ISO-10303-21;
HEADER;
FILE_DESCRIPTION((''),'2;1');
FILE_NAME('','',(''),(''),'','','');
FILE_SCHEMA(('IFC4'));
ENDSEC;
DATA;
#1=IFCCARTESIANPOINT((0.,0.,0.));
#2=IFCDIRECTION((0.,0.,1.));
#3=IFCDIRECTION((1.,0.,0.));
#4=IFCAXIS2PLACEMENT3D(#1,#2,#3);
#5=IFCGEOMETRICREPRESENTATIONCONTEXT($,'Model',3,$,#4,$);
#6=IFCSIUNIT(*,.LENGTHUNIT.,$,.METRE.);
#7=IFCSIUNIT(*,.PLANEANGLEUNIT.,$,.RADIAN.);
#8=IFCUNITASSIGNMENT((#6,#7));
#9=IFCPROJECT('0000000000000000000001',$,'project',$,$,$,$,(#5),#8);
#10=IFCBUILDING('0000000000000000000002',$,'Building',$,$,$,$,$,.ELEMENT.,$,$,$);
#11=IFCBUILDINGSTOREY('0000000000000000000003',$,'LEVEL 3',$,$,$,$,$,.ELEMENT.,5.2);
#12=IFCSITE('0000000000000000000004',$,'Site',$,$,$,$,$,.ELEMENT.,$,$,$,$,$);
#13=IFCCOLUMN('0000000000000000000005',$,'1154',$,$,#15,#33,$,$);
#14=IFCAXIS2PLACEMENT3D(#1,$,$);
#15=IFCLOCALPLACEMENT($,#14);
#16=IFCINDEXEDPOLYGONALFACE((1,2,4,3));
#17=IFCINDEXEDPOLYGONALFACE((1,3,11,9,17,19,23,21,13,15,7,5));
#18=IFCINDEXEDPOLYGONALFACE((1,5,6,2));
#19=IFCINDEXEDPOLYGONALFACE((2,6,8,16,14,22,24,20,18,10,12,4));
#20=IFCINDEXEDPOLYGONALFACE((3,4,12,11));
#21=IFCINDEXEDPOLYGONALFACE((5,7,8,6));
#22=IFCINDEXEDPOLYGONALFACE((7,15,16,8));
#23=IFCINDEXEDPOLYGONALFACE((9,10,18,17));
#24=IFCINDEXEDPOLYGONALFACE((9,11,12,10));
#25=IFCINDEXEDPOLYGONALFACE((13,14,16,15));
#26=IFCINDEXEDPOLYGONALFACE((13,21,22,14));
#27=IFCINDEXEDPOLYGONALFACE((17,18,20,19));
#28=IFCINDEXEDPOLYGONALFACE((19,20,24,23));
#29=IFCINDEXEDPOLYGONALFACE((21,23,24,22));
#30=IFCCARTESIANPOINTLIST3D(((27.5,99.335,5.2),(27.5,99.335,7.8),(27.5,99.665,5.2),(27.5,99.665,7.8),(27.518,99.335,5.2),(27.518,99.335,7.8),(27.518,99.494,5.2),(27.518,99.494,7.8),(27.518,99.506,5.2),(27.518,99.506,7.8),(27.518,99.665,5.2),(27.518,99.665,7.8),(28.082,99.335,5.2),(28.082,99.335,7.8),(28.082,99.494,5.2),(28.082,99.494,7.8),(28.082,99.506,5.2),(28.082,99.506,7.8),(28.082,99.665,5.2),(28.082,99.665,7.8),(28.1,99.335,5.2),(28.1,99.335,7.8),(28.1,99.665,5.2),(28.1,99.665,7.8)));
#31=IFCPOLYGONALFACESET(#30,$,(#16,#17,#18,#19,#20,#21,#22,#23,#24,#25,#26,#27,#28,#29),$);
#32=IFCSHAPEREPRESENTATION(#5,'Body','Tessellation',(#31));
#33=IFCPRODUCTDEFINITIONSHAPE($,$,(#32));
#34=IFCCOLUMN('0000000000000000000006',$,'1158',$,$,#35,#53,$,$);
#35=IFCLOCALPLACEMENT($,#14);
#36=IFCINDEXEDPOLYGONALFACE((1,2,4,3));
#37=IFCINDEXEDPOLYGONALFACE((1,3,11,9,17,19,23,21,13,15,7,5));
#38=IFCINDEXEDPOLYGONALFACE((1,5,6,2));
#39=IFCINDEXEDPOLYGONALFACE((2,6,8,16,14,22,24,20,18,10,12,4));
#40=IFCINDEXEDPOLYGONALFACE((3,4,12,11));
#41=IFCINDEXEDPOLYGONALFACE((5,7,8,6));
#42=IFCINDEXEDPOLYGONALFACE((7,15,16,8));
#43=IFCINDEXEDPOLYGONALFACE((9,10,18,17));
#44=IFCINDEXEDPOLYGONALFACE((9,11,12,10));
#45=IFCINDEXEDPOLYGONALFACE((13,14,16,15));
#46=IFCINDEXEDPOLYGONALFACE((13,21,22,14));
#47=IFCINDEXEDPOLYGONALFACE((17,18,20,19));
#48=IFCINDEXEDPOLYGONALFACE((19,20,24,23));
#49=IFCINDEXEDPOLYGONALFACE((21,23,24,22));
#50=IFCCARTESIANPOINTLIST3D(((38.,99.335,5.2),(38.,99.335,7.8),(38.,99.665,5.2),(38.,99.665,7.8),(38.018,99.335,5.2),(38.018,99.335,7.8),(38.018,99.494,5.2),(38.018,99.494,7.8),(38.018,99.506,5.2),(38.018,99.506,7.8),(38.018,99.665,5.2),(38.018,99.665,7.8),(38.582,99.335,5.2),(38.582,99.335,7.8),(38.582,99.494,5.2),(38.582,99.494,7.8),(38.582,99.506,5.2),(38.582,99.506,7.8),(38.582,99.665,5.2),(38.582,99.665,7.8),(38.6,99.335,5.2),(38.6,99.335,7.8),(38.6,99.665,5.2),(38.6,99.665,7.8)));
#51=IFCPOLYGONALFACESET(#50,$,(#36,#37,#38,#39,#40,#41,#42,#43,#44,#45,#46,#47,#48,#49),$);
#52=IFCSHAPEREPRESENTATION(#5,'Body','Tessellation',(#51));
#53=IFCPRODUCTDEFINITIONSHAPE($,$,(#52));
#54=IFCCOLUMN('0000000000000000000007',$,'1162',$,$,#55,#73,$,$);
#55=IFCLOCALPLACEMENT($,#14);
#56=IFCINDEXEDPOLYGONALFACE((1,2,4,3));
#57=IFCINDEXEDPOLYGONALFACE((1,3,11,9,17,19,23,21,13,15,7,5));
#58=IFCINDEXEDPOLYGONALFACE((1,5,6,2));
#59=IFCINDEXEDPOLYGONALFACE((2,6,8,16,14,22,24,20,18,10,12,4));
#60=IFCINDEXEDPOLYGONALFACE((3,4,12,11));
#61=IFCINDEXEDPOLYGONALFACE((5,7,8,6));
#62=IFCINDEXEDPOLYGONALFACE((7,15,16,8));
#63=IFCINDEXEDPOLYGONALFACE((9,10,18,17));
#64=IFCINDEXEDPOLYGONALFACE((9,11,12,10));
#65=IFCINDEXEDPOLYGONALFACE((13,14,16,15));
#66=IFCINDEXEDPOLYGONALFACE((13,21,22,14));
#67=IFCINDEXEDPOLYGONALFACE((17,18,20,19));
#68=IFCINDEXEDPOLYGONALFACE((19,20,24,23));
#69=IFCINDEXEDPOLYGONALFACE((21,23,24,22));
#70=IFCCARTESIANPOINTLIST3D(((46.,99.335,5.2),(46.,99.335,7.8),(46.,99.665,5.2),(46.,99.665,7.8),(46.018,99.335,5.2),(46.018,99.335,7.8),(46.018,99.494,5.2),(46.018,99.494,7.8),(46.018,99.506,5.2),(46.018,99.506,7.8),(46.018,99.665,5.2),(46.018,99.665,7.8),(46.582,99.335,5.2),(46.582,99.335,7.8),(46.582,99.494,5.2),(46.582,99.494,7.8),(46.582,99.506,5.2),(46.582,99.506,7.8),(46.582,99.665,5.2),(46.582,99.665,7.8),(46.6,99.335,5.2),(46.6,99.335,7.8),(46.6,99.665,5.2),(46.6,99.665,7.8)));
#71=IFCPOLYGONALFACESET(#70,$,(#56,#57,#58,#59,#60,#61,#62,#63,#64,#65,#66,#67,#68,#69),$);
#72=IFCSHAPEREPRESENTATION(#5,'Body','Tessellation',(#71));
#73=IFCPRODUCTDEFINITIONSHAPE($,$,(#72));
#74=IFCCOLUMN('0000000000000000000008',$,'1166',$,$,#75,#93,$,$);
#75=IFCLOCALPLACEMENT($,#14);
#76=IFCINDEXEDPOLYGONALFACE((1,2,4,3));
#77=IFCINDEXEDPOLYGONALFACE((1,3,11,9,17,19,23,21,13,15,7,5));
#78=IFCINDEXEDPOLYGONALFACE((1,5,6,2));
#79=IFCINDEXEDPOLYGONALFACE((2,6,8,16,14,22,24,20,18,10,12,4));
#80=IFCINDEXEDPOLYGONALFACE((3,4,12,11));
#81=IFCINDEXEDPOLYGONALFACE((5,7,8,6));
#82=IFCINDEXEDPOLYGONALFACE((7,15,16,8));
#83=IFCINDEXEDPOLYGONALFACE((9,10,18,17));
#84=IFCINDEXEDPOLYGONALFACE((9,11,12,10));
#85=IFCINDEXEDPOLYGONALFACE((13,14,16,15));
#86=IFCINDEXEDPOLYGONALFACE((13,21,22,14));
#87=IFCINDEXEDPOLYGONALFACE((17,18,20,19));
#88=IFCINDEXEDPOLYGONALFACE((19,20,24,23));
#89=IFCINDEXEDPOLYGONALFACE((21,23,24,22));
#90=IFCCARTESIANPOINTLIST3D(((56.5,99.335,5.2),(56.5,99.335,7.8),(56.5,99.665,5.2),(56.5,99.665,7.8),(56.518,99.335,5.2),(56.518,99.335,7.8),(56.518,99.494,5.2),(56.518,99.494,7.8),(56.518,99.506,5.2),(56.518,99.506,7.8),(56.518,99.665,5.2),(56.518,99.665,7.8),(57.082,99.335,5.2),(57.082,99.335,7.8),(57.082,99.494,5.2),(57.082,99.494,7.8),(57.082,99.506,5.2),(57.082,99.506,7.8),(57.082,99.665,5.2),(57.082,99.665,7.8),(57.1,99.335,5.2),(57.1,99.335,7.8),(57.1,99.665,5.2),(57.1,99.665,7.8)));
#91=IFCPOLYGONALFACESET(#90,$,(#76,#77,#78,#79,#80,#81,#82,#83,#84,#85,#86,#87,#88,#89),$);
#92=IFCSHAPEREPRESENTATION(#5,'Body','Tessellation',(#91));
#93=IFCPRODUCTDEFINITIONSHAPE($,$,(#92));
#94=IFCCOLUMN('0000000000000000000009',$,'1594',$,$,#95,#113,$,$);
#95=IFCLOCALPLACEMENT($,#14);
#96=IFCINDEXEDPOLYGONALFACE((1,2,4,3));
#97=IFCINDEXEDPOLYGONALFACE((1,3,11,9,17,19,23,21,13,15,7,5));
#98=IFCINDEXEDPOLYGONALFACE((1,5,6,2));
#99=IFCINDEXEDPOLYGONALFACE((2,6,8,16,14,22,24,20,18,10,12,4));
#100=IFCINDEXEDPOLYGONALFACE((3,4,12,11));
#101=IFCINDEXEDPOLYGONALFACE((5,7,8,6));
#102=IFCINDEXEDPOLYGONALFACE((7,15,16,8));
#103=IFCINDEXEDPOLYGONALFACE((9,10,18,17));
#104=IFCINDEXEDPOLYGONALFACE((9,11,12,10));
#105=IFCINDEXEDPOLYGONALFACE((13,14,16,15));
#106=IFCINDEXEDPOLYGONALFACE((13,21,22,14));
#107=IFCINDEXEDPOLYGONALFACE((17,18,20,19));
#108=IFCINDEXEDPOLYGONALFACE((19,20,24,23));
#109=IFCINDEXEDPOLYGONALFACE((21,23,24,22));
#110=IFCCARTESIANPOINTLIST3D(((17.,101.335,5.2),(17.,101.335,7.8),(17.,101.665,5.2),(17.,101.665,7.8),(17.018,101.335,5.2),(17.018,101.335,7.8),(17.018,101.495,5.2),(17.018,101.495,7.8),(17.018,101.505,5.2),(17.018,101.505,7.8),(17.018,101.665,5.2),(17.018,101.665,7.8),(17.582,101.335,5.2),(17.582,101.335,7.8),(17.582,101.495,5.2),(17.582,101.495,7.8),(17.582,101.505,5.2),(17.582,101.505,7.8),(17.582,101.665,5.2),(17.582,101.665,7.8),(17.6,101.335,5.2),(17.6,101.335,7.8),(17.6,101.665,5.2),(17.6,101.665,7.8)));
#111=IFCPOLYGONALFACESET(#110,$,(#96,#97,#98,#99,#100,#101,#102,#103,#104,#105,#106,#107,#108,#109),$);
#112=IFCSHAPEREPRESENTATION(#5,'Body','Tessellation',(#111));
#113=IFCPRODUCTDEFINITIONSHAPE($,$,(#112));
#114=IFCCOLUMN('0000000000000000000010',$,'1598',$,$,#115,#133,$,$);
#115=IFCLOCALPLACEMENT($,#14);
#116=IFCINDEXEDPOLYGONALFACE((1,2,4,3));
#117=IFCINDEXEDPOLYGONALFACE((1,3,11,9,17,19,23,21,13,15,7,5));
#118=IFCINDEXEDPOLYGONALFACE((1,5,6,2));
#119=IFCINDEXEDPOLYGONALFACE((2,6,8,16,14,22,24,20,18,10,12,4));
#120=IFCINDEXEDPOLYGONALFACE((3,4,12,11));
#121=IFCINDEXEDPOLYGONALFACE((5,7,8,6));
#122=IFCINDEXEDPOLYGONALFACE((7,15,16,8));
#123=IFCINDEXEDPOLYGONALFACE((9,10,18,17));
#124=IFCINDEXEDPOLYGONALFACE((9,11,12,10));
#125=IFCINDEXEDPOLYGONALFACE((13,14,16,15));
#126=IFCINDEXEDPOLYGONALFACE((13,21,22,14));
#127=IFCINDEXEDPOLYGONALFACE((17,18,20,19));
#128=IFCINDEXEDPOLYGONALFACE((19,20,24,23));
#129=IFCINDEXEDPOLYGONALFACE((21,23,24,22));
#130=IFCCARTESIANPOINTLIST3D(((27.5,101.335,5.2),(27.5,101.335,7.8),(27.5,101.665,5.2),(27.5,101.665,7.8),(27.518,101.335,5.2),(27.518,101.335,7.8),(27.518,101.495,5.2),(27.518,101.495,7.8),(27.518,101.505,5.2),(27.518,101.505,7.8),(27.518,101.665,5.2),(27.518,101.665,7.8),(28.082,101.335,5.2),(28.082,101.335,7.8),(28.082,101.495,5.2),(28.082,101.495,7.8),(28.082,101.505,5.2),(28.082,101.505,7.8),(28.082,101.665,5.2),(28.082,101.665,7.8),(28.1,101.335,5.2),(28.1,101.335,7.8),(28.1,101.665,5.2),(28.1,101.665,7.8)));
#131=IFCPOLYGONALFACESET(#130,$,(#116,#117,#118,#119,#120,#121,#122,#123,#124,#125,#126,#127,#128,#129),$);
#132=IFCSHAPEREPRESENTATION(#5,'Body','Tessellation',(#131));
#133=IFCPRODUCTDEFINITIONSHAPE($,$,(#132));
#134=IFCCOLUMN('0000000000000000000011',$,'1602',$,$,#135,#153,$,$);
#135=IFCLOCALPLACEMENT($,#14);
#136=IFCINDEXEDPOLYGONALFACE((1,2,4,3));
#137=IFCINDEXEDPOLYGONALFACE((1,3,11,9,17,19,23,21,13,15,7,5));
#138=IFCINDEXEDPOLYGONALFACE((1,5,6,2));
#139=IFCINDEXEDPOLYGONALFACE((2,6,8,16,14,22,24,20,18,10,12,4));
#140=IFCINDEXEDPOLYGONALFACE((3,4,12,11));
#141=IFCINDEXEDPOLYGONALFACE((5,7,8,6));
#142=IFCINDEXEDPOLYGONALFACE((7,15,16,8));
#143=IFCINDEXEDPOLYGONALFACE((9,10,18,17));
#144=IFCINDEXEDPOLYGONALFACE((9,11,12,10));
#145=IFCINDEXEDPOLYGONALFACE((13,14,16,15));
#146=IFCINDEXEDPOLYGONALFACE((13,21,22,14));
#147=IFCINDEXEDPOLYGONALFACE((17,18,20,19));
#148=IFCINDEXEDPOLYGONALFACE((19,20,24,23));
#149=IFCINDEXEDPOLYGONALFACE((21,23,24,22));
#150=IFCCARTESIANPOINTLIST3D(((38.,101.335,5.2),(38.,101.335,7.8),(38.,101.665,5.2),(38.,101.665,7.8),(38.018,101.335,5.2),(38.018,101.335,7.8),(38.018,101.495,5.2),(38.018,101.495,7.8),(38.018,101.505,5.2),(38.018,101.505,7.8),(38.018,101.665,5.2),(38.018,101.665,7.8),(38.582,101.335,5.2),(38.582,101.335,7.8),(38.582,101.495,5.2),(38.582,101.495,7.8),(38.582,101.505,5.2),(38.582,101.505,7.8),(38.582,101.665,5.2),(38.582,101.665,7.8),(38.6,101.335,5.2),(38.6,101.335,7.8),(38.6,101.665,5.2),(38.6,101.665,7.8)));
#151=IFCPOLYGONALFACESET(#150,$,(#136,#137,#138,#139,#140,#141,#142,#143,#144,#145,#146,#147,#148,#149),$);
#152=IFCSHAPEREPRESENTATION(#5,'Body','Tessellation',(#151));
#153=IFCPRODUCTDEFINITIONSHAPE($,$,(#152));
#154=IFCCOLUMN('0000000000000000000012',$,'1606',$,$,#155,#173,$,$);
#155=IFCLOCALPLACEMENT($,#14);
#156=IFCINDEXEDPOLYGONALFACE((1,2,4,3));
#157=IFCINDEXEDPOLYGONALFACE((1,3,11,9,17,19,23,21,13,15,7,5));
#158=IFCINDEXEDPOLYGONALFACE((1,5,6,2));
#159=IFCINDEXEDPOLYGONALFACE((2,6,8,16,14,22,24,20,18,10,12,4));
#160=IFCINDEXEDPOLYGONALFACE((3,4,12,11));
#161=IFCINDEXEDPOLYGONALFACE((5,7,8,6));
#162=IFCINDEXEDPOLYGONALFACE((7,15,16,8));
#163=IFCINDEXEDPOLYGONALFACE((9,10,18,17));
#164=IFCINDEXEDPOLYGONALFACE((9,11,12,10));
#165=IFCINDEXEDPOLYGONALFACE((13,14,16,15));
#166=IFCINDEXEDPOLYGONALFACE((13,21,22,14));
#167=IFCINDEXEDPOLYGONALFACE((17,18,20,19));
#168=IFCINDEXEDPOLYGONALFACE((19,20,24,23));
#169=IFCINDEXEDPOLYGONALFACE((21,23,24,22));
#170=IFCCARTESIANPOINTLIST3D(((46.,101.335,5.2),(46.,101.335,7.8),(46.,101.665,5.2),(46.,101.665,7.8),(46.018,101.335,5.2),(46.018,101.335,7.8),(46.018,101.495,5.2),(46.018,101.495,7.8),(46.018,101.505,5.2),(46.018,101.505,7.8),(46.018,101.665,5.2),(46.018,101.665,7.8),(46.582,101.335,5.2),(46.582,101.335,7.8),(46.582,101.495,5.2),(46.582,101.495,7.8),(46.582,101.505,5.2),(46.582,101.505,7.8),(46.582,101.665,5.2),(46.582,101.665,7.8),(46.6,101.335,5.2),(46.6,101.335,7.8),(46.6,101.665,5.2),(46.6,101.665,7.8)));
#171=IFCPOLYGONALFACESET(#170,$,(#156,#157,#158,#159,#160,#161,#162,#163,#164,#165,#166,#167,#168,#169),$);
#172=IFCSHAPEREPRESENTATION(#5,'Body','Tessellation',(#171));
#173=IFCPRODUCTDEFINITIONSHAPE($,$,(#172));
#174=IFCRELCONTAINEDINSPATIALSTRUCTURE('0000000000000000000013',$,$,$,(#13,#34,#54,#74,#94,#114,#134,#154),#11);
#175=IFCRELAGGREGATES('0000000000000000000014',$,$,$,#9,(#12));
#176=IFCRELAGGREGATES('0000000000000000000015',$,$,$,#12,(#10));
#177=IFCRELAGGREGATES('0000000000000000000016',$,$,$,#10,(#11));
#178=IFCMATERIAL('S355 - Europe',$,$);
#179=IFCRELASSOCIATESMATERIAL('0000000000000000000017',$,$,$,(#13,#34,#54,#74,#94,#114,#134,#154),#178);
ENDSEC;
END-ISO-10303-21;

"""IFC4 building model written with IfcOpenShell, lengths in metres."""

from ifc_helpers import new_model, si_unit, frame, origin_with_axes, origin_2d_with_axis, place, context, project, spatial, i_section, extrude, material, material_profile, profile_set, profile_usage, element, save


model = new_model("IFC4")

# Units and contexts
model_context = context("Model", 3, world=origin_with_axes())
ifc_project = project(units=[si_unit("LENGTHUNIT", "METRE"), si_unit("PLANEANGLEUNIT", "RADIAN")], contexts=[model_context])

# Site, building, storey
site = spatial("IfcSite", under=ifc_project, Name="Site", CompositionType="ELEMENT")
building = spatial("IfcBuilding", under=site, Name="Building", CompositionType="ELEMENT")
storey = spatial("IfcBuildingStorey", under=building, Name="LEVEL 3", CompositionType="ELEMENT", Elevation=5.2)

# Columns
ifc_material = material(Name="S355 - Europe")
ifc_material_profile_1 = material_profile(ifc_material, i_section(OverallWidth=0.33, OverallDepth=0.6, WebThickness=0.012, FlangeThickness=0.018, at=origin_2d_with_axis()))
ifc_profile_set_1 = profile_set([ifc_material_profile_1])
ifc_profile_usage_1 = profile_usage(ifc_profile_set_1, cardinal=10)
column_1_placement = place(None, frame((27.8, 99.5, 5.2), z_axis=(0.0, 0.0, 1.0), x_axis=(0.0, -1.0, 0.0)))
element("IfcColumn", 1, at=column_1_placement, inside=storey, material=ifc_profile_usage_1, Name="1154", context=model_context, shape_type="SweptSolid", body=[
    extrude(i_section(OverallWidth=0.33, OverallDepth=0.6, WebThickness=0.012, FlangeThickness=0.018, at=origin_2d_with_axis()), origin_with_axes(), (0.0, 0.0, 1.0), 2.6),
])
ifc_material_profile_2 = material_profile(ifc_material, i_section(OverallWidth=0.33, OverallDepth=0.6, WebThickness=0.012, FlangeThickness=0.018, at=origin_2d_with_axis()))
ifc_profile_set_2 = profile_set([ifc_material_profile_2])
ifc_profile_usage_2 = profile_usage(ifc_profile_set_2, cardinal=10)
column_2_placement = place(None, frame((38.3, 99.5, 5.2), z_axis=(0.0, 0.0, 1.0), x_axis=(0.0, -1.0, 0.0)))
element("IfcColumn", 2, at=column_2_placement, inside=storey, material=ifc_profile_usage_2, Name="1158", context=model_context, shape_type="SweptSolid", body=[
    extrude(i_section(OverallWidth=0.33, OverallDepth=0.6, WebThickness=0.012, FlangeThickness=0.018, at=origin_2d_with_axis()), origin_with_axes(), (0.0, 0.0, 1.0), 2.6),
])
ifc_material_profile_3 = material_profile(ifc_material, i_section(OverallWidth=0.33, OverallDepth=0.6, WebThickness=0.012, FlangeThickness=0.018, at=origin_2d_with_axis()))
ifc_profile_set_3 = profile_set([ifc_material_profile_3])
ifc_profile_usage_3 = profile_usage(ifc_profile_set_3, cardinal=10)
column_3_placement = place(None, frame((46.3, 99.5, 5.2), z_axis=(0.0, 0.0, 1.0), x_axis=(0.0, -1.0, 0.0)))
element("IfcColumn", 3, at=column_3_placement, inside=storey, material=ifc_profile_usage_3, Name="1162", context=model_context, shape_type="SweptSolid", body=[
    extrude(i_section(OverallWidth=0.33, OverallDepth=0.6, WebThickness=0.012, FlangeThickness=0.018, at=origin_2d_with_axis()), origin_with_axes(), (0.0, 0.0, 1.0), 2.6),
])
ifc_material_profile_4 = material_profile(ifc_material, i_section(OverallWidth=0.33, OverallDepth=0.6, WebThickness=0.012, FlangeThickness=0.018, at=origin_2d_with_axis()))
ifc_profile_set_4 = profile_set([ifc_material_profile_4])
ifc_profile_usage_4 = profile_usage(ifc_profile_set_4, cardinal=10)
column_4_placement = place(None, frame((56.8, 99.5, 5.2), z_axis=(0.0, 0.0, 1.0), x_axis=(0.0, -1.0, 0.0)))
element("IfcColumn", 4, at=column_4_placement, inside=storey, material=ifc_profile_usage_4, Name="1166", context=model_context, shape_type="SweptSolid", body=[
    extrude(i_section(OverallWidth=0.33, OverallDepth=0.6, WebThickness=0.012, FlangeThickness=0.018, at=origin_2d_with_axis()), origin_with_axes(), (0.0, 0.0, 1.0), 2.6),
])
ifc_material_profile_5 = material_profile(ifc_material, i_section(OverallWidth=0.33, OverallDepth=0.6, WebThickness=0.01, FlangeThickness=0.018, at=origin_2d_with_axis()))
ifc_profile_set_5 = profile_set([ifc_material_profile_5])
ifc_profile_usage_5 = profile_usage(ifc_profile_set_5, cardinal=10)
column_5_placement = place(None, frame((17.3, 101.5, 5.2), z_axis=(0.0, 0.0, 1.0), x_axis=(0.0, -1.0, 0.0)))
element("IfcColumn", 5, at=column_5_placement, inside=storey, material=ifc_profile_usage_5, Name="1594", context=model_context, shape_type="SweptSolid", body=[
    extrude(i_section(OverallWidth=0.33, OverallDepth=0.6, WebThickness=0.01, FlangeThickness=0.018, at=origin_2d_with_axis()), origin_with_axes(), (0.0, 0.0, 1.0), 2.6),
])
ifc_material_profile_6 = material_profile(ifc_material, i_section(OverallWidth=0.33, OverallDepth=0.6, WebThickness=0.01, FlangeThickness=0.018, at=origin_2d_with_axis()))
ifc_profile_set_6 = profile_set([ifc_material_profile_6])
ifc_profile_usage_6 = profile_usage(ifc_profile_set_6, cardinal=10)
column_6_placement = place(None, frame((27.8, 101.5, 5.2), z_axis=(0.0, 0.0, 1.0), x_axis=(0.0, -1.0, 0.0)))
element("IfcColumn", 6, at=column_6_placement, inside=storey, material=ifc_profile_usage_6, Name="1598", context=model_context, shape_type="SweptSolid", body=[
    extrude(i_section(OverallWidth=0.33, OverallDepth=0.6, WebThickness=0.01, FlangeThickness=0.018, at=origin_2d_with_axis()), origin_with_axes(), (0.0, 0.0, 1.0), 2.6),
])
ifc_material_profile_7 = material_profile(ifc_material, i_section(OverallWidth=0.33, OverallDepth=0.6, WebThickness=0.01, FlangeThickness=0.018, at=origin_2d_with_axis()))
ifc_profile_set_7 = profile_set([ifc_material_profile_7])
ifc_profile_usage_7 = profile_usage(ifc_profile_set_7, cardinal=10)
column_7_placement = place(None, frame((38.3, 101.5, 5.2), z_axis=(0.0, 0.0, 1.0), x_axis=(0.0, -1.0, 0.0)))
element("IfcColumn", 7, at=column_7_placement, inside=storey, material=ifc_profile_usage_7, Name="1602", context=model_context, shape_type="SweptSolid", body=[
    extrude(i_section(OverallWidth=0.33, OverallDepth=0.6, WebThickness=0.01, FlangeThickness=0.018, at=origin_2d_with_axis()), origin_with_axes(), (0.0, 0.0, 1.0), 2.6),
])
ifc_material_profile_8 = material_profile(ifc_material, i_section(OverallWidth=0.33, OverallDepth=0.6, WebThickness=0.01, FlangeThickness=0.018, at=origin_2d_with_axis()))
ifc_profile_set_8 = profile_set([ifc_material_profile_8])
ifc_profile_usage_8 = profile_usage(ifc_profile_set_8, cardinal=10)
column_8_placement = place(None, frame((46.3, 101.5, 5.2), z_axis=(0.0, 0.0, 1.0), x_axis=(0.0, -1.0, 0.0)))
element("IfcColumn", 8, at=column_8_placement, inside=storey, material=ifc_profile_usage_8, Name="1606", context=model_context, shape_type="SweptSolid", body=[
    extrude(i_section(OverallWidth=0.33, OverallDepth=0.6, WebThickness=0.01, FlangeThickness=0.018, at=origin_2d_with_axis()), origin_with_axes(), (0.0, 0.0, 1.0), 2.6),
])

save(model, "model.ifc")
